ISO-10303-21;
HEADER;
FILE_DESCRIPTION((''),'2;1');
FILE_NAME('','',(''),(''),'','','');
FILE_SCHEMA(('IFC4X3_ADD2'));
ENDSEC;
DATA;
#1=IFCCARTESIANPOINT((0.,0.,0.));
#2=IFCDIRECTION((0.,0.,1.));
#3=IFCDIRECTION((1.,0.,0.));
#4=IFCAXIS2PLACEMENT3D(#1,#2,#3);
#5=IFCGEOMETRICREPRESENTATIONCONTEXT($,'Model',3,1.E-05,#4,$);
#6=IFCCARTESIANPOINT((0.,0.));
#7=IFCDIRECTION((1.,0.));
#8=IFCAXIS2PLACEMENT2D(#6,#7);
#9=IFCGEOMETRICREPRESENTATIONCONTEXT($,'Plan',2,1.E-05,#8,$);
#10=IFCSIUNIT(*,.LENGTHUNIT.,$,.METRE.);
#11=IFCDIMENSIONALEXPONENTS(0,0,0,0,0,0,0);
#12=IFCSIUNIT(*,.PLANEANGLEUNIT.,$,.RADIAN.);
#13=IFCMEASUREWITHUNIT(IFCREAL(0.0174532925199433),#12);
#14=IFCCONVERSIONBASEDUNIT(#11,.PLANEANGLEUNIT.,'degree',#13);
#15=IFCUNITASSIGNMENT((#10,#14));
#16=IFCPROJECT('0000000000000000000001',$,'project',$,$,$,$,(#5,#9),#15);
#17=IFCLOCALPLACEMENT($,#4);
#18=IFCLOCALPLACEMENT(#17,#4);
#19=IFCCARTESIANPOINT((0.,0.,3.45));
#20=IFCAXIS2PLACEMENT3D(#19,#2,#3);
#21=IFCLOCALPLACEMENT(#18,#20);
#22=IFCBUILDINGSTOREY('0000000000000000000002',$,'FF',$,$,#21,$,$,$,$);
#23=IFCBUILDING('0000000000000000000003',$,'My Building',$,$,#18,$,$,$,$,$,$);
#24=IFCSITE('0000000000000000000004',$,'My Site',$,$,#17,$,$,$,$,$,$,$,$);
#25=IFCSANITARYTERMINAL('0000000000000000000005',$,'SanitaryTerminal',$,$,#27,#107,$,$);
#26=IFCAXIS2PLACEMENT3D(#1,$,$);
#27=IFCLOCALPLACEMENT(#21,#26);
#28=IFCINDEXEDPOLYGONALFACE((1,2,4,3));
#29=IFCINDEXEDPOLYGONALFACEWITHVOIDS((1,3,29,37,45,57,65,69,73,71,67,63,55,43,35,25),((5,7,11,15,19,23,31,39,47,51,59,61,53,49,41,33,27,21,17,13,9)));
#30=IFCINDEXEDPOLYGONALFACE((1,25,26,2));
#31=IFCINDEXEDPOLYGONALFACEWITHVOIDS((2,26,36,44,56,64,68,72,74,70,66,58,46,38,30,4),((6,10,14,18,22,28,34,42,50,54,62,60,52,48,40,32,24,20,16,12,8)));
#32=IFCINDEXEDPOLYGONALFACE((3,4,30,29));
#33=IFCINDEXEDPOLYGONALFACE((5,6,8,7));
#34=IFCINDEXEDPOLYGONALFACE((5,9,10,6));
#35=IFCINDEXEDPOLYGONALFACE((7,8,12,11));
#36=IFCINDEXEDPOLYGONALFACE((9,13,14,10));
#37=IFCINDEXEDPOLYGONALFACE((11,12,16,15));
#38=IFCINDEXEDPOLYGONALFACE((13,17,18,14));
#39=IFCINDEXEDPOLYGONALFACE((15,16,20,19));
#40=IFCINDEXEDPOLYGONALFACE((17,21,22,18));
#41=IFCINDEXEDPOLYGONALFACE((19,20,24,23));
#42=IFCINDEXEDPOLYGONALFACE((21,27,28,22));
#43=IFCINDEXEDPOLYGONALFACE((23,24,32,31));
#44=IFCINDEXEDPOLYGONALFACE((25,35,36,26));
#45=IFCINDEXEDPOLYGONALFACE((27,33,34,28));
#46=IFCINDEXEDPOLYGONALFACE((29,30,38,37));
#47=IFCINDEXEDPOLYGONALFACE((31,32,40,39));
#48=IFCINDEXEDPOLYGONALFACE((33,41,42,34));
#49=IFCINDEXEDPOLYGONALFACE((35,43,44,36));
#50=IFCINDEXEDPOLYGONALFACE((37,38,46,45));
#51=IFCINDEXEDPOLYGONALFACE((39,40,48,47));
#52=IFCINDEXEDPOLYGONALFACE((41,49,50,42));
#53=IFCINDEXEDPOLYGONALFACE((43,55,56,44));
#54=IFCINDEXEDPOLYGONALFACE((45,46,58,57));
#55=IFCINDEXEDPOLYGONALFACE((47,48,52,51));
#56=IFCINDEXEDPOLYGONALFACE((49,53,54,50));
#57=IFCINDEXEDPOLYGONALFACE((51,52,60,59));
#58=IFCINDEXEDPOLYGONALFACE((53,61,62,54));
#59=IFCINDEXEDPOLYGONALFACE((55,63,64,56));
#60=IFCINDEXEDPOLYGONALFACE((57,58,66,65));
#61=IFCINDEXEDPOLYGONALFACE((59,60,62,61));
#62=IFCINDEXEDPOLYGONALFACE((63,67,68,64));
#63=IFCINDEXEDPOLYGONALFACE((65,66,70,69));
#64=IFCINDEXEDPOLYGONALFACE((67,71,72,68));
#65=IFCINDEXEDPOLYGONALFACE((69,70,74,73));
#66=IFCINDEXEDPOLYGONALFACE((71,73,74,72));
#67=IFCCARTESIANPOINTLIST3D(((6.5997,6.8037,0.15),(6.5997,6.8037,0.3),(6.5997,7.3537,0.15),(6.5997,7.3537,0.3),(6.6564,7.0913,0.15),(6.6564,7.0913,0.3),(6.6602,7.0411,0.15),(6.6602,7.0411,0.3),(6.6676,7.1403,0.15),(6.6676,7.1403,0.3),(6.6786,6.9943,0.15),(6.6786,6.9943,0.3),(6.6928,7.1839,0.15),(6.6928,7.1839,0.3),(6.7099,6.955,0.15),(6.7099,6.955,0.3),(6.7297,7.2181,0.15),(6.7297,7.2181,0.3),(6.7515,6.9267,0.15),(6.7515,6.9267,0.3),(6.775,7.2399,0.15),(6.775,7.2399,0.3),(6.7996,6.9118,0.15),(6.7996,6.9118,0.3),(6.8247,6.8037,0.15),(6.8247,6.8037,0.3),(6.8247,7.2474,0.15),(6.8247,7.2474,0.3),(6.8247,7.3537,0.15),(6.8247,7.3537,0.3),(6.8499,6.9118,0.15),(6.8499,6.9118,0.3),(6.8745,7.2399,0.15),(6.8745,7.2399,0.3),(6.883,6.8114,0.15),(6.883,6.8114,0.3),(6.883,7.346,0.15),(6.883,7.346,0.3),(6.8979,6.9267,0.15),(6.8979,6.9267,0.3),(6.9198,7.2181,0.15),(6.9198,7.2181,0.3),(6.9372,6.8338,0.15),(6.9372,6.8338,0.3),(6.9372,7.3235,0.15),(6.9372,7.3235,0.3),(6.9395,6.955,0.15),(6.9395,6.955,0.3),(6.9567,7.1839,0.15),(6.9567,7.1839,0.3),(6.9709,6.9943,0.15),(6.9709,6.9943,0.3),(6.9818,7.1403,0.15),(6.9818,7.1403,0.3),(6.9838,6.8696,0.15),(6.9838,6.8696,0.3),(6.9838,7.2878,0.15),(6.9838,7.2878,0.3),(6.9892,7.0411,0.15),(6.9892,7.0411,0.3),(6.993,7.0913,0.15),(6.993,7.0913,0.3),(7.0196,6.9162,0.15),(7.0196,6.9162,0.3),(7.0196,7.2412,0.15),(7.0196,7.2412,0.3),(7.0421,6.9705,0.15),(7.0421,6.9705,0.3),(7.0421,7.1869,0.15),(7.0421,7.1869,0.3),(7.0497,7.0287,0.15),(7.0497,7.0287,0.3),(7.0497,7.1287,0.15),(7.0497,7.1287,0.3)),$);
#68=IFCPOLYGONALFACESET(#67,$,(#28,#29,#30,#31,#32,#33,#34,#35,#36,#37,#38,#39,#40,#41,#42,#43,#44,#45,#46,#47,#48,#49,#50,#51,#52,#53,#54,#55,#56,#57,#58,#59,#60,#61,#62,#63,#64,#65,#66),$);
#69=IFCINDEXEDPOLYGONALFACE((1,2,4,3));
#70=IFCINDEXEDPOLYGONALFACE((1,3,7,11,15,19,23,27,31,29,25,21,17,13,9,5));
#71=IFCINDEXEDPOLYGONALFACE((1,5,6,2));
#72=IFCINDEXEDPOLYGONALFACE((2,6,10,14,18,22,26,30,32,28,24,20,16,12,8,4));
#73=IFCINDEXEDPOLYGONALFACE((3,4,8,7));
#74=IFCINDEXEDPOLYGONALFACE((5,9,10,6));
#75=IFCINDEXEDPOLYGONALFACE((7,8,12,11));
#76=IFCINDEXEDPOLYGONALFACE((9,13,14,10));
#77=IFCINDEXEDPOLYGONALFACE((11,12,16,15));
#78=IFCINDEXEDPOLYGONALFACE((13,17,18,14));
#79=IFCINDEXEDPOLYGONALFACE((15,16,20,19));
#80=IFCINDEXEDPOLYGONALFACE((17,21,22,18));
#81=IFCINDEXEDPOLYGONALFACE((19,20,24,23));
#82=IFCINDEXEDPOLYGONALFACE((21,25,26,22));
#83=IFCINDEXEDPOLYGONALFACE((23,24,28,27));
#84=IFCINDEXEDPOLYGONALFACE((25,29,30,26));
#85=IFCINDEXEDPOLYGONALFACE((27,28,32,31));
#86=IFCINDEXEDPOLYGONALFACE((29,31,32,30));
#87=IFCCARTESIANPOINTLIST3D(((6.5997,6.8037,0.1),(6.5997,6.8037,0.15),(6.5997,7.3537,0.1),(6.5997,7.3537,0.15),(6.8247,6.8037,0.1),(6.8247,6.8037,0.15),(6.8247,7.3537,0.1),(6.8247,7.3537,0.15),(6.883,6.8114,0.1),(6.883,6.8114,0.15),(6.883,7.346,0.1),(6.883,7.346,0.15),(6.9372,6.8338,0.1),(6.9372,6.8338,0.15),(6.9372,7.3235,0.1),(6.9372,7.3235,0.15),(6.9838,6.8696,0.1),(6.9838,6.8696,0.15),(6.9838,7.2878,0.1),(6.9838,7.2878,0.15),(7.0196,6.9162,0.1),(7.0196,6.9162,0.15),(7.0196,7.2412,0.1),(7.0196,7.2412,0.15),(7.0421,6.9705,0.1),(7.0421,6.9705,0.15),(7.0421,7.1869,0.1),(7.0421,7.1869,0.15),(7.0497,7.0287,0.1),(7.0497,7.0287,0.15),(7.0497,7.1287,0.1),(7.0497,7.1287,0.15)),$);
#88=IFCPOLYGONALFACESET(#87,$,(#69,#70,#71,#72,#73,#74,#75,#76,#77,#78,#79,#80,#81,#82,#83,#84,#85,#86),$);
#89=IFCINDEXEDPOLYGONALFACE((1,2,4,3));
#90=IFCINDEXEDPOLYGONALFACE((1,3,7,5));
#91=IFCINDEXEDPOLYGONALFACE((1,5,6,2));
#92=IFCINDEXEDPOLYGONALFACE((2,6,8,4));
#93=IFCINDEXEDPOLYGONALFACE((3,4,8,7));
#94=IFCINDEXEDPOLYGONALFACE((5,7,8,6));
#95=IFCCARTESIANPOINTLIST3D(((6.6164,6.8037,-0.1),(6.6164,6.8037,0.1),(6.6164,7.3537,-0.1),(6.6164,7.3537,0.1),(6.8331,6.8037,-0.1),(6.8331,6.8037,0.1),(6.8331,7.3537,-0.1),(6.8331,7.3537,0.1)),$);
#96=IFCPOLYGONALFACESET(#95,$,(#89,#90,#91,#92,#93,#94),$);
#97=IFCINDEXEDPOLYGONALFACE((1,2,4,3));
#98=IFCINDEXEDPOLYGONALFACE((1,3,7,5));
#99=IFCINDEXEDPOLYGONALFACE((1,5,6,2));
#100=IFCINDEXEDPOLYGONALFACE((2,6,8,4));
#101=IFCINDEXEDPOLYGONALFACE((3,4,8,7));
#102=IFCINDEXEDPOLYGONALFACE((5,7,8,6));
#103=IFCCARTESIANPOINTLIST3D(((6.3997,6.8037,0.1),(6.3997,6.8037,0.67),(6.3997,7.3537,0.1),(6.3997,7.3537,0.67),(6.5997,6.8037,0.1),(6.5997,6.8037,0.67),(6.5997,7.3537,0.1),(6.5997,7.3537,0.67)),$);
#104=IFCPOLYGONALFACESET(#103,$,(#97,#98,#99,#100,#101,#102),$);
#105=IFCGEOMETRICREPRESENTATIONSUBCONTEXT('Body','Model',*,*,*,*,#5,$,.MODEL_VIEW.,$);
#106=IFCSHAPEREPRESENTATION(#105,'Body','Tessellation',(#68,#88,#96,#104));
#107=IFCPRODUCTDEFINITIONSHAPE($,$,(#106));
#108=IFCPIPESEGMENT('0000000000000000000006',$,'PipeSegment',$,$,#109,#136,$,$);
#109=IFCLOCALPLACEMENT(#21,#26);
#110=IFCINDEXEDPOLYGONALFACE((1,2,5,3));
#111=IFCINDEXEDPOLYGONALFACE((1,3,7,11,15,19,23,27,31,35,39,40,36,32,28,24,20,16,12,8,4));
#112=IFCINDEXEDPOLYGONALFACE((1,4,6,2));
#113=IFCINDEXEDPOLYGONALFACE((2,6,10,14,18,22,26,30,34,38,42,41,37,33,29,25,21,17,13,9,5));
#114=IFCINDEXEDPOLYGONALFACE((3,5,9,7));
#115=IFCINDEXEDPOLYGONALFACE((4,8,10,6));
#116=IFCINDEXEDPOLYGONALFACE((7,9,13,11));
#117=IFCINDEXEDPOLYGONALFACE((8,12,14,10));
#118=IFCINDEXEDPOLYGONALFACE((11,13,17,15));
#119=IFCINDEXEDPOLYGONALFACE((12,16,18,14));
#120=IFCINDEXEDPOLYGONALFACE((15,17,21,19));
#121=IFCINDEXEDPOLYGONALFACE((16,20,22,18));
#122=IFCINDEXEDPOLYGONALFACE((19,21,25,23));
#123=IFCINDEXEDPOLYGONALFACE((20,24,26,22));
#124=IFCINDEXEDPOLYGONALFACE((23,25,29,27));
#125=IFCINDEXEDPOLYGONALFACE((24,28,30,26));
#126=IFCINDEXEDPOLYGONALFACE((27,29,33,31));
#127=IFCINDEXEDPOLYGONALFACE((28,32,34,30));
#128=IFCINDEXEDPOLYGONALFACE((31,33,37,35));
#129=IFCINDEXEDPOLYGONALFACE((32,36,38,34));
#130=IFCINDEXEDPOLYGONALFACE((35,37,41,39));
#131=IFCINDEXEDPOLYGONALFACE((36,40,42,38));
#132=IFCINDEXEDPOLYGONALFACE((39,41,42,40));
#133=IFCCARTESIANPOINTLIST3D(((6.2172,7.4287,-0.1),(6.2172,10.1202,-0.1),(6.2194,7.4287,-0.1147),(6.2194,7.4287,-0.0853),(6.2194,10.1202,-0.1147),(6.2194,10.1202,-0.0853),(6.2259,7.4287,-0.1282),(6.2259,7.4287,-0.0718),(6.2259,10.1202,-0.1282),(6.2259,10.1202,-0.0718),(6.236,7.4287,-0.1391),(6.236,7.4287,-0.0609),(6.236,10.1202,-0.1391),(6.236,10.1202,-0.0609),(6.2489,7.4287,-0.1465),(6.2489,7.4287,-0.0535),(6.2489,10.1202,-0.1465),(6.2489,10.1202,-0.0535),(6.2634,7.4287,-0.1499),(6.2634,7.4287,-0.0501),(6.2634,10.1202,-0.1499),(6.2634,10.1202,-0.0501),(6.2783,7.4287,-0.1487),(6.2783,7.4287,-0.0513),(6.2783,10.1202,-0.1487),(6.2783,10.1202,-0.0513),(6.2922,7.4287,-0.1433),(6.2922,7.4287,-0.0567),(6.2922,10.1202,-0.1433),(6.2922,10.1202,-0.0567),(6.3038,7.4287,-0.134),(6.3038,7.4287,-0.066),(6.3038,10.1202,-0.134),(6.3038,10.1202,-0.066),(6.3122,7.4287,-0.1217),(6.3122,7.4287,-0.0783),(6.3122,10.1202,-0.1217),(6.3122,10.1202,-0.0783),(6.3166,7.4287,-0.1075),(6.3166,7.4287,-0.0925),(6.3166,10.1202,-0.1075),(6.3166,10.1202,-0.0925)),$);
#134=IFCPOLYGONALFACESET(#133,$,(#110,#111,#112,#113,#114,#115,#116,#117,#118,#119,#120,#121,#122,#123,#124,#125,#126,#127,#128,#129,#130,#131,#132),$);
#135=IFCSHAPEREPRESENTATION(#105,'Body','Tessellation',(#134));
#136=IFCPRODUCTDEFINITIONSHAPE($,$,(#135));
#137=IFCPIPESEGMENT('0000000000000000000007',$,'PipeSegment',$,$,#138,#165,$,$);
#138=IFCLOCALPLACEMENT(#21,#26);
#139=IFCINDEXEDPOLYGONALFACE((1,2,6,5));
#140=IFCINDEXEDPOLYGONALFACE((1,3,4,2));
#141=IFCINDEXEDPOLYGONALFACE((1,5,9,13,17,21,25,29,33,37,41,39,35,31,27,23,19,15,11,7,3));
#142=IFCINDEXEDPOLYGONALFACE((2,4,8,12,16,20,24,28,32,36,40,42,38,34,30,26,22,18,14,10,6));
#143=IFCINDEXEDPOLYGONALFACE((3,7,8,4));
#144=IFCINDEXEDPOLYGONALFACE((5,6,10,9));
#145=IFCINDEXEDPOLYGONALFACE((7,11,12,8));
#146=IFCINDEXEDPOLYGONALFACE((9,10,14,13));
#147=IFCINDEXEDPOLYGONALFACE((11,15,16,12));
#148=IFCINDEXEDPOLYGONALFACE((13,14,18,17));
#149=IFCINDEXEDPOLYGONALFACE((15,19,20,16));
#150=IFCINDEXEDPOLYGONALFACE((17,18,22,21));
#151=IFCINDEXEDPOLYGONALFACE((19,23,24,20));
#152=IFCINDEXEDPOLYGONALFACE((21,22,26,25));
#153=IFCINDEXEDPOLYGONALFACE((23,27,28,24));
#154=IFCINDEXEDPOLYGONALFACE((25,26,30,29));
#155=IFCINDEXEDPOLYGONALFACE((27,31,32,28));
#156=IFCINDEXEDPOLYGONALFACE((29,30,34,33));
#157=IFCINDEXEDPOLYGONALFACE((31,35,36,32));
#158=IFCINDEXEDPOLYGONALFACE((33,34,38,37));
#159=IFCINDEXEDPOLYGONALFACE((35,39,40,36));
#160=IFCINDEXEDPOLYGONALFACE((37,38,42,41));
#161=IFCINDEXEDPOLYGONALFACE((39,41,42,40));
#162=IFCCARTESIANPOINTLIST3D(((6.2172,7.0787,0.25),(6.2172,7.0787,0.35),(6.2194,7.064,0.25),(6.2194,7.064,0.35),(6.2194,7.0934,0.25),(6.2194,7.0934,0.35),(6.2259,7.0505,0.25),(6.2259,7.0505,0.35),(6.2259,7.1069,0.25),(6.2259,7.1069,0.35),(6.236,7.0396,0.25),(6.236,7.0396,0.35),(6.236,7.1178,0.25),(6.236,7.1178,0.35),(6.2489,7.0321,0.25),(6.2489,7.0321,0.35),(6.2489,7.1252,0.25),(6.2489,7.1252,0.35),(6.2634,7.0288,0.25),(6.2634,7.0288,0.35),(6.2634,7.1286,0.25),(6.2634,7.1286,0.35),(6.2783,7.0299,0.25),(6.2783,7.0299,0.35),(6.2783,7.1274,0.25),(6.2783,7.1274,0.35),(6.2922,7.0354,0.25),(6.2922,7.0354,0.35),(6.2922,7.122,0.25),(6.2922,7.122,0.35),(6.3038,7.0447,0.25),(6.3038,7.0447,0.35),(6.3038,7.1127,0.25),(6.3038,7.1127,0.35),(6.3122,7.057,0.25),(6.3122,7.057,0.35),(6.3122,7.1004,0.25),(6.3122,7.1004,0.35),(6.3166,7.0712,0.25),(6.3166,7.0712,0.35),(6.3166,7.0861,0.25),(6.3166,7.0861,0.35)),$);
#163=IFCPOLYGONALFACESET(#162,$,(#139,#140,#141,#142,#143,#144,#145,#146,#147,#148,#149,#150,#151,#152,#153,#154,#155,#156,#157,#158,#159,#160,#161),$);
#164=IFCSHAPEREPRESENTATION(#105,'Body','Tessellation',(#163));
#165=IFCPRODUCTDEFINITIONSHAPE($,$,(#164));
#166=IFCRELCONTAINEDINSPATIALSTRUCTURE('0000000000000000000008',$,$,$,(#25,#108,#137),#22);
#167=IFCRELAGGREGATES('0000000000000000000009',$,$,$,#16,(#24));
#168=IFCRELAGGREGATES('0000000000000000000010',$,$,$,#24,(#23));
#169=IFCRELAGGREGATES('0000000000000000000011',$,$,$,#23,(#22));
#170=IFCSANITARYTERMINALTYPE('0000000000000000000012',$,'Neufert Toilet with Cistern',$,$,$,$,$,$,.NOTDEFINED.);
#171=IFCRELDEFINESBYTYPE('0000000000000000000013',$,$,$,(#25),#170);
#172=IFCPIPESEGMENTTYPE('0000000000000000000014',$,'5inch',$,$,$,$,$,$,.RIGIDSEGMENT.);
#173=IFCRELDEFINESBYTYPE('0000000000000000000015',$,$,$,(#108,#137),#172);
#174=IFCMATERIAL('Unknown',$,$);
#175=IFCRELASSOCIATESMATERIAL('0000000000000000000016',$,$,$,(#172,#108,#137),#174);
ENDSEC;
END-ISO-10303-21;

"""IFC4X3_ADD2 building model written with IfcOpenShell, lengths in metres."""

from ifc_helpers import new_model, entity, si_unit, converted_unit, frame, frame_2d, origin_with_axes, origin_2d_with_axis, place, context, subcontext, project, spatial, line, arc, indexed_curve, circle_curve, circle, outline, extrude, shape, source, transform, mapped, material, material_profile, profile_set, profile_usage, type_object, type_shapes, element, save


model = new_model("IFC4X3_ADD2")

# Units and contexts
model_context = context("Model", 3, precision=1e-05, world=origin_with_axes())
plan_context = context("Plan", 2, precision=1e-05, world=origin_2d_with_axis())
body_context_1 = subcontext(model_context, "Body", "Model", "MODEL_VIEW")
body_context_2 = subcontext(plan_context, "Body", "Plan", "PLAN_VIEW")
ifc_project = project(units=[si_unit("LENGTHUNIT", "METRE"), converted_unit("PLANEANGLEUNIT", "degree", entity("IfcReal", 0.0174532925199433), si_unit("PLANEANGLEUNIT", "RADIAN"), dimensions=[0, 0, 0, 0, 0, 0, 0])], contexts=[model_context, plan_context])

# Site, building, storey
site_placement = place(None, origin_with_axes())
site = spatial("IfcSite", under=ifc_project, at=site_placement, Name="My Site")
building_placement = place(site_placement, origin_with_axes())
building = spatial("IfcBuilding", under=site, at=building_placement, Name="My Building")
storey_placement = place(building_placement, frame((0.0, 0.0, 3.45), z_axis=(0.0, 0.0, 1.0), x_axis=(1.0, 0.0, 0.0)))
storey = spatial("IfcBuildingStorey", under=building, at=storey_placement, Name="FF")

# Shared definitions
ifc_material = material(Name="Unknown")

# Sanitary terminal
sanitary_terminal_type = type_object("IfcSanitaryTerminalType", Name="Neufert Toilet with Cistern", PredefinedType="NOTDEFINED")
shared_shape_1 = source(origin_with_axes(), body_context_1, "Body", "SweptSolid", [
    extrude(outline(indexed_curve([(-0.275, -0.2), (0.275, -0.2), (0.275, -0.425), (0.2091, -0.5841), (0.05, -0.65), (-0.05, -0.65), (-0.2091, -0.5841), (-0.275, -0.425), (0.0, -0.5938), (0.0, -0.2563)], segments=[arc(8, 7, 6), line(6, 5), arc(5, 4, 3), line(3, 2), line(2, 1), line(1, 8)], self_intersect=False), holes=[circle_curve(frame_2d((0.0, -0.425)), 0.1687)]), frame((0.0, 0.0, 0.25), z_axis=(0.0, 0.0, 1.0), x_axis=(1.0, 0.0, 0.0)), (0.0, 0.0, 1.0), 0.15),
    extrude(outline(indexed_curve([(-0.275, -0.2), (0.275, -0.2), (0.275, -0.425), (0.2091, -0.5841), (0.05, -0.65), (-0.05, -0.65), (-0.2091, -0.5841), (-0.275, -0.425)], segments=[line(1, 2), line(2, 3), arc(3, 4, 5), line(5, 6), arc(6, 7, 8), line(8, 1)])), frame((0.0, 0.0, 0.2), z_axis=(0.0, 0.0, 1.0), x_axis=(1.0, 0.0, 0.0)), (0.0, 0.0, 1.0), 0.05),
    extrude(outline(indexed_curve([(-0.275, -0.2167), (0.275, -0.2167), (0.275, -0.4333), (-0.275, -0.4333)], segments=[line(1, 2, 3, 4, 1)])), origin_with_axes(), (0.0, 0.0, 1.0), 0.2),
    extrude(outline(indexed_curve([(-0.275, 0.0), (0.275, 0.0), (0.275, -0.2), (-0.275, -0.2)], segments=[line(1, 2, 3, 4, 1)])), frame((0.0, 0.0, 0.2), z_axis=(0.0, 0.0, 1.0), x_axis=(1.0, 0.0, 0.0)), (0.0, 0.0, 1.0), 0.57),
])
shared_shape_2 = source(origin_with_axes(), body_context_2, "Body", "Curve2D", [
    entity("IfcIndexedPolyCurve", entity("IfcCartesianPointList2D", [[-0.275, 0.0], [0.275, 0.0], [0.275, -0.2], [-0.275, -0.2]]), [entity("IfcLineIndex", [1, 2, 3, 4, 1])]),
    entity("IfcIndexedPolyCurve", entity("IfcCartesianPointList2D", [[0.165, -0.2], [0.1925, -0.335]])),
    entity("IfcTrimmedCurve", entity("IfcEllipse", entity("IfcAxis2Placement2D", entity("IfcCartesianPoint", [0.0, -0.335]), entity("IfcDirection", [1.0, 0.0])), 0.1925, 0.315), [entity("IfcCartesianPoint", [-0.1925, -0.335])], [entity("IfcCartesianPoint", [0.1925, -0.335])], True, "CARTESIAN"),
    entity("IfcIndexedPolyCurve", entity("IfcCartesianPointList2D", [[-0.165, -0.2], [-0.1925, -0.335]])),
    entity("IfcEllipse", entity("IfcAxis2Placement2D", entity("IfcCartesianPoint", [0.0, -0.452]), entity("IfcDirection", [1.0, 0.0])), 0.1313, 0.1575),
    entity("IfcIndexedPolyCurve", entity("IfcCartesianPointList2D", [[-0.0344, -0.452], [-0.0344, -0.4295], [0.0344, -0.4295], [0.0344, -0.452]])),
    entity("IfcTrimmedCurve", entity("IfcEllipse", entity("IfcAxis2Placement2D", entity("IfcCartesianPoint", [0.0, -0.452]), entity("IfcDirection", [1.0, 0.0])), 0.0344, 0.0225), [entity("IfcCartesianPoint", [-0.0344, -0.452])], [entity("IfcCartesianPoint", [0.0344, -0.452])], True, "CARTESIAN"),
])
type_shapes(sanitary_terminal_type, [shared_shape_1, shared_shape_2])
sanitary_terminal_placement = place(storey_placement, frame((6.3997, 7.0787, -0.1), z_axis=(0.0, 0.0, 1.0), x_axis=(0.0, 1.0, 0.0)))
element("IfcSanitaryTerminal", 1, at=sanitary_terminal_placement, inside=storey, type_object=sanitary_terminal_type, Name="SanitaryTerminal", shapes=[
    shape(body_context_1, "Body", "MappedRepresentation", [mapped(shared_shape_1, transform((0.0, 0.0, 0.0), x_axis=(1.0, 0.0, 0.0), y_axis=(0.0, 1.0, 0.0), z_axis=(0.0, 0.0, 1.0), scale=1.0))]),
    shape(body_context_2, "Body", "MappedRepresentation", [mapped(shared_shape_2, transform((0.0, 0.0, 0.0), x_axis=(1.0, 0.0, 0.0), y_axis=(0.0, 1.0, 0.0), z_axis=(0.0, 0.0, 1.0), scale=1.0))]),
])

# Pipe segments
ifc_material_profile_1 = material_profile(ifc_material, circle(Radius=0.05))
ifc_profile_set_1 = profile_set([ifc_material_profile_1])
ifc_profile_usage_1 = profile_usage(ifc_profile_set_1, cardinal=5)
pipe_segment_type_1 = type_object("IfcPipeSegmentType", Name="5inch", PredefinedType="RIGIDSEGMENT", material=ifc_profile_set_1)
pipe_segment_1_placement = place(storey_placement, frame((6.2672, 7.4287, -0.1), z_axis=(0.0, 1.0, 0.0), x_axis=(-1.0, 0.0, 0.0)))
element("IfcPipeSegment", 2, at=pipe_segment_1_placement, inside=storey, type_object=pipe_segment_type_1, material=ifc_profile_usage_1, Name="PipeSegment", context=body_context_1, shape_type="SweptSolid", body=[
    extrude(circle(Radius=0.05), origin_with_axes(), (0.0, 0.0, 1.0), 2.6915),
])
ifc_profile_usage_2 = profile_usage(ifc_profile_set_1, cardinal=5)
pipe_segment_2_placement = place(storey_placement, frame((6.2672, 7.0787, 0.25), z_axis=(0.0, 0.0, 1.0), x_axis=(-1.0, 0.0, 0.0)))
element("IfcPipeSegment", 3, at=pipe_segment_2_placement, inside=storey, type_object=pipe_segment_type_1, material=ifc_profile_usage_2, Name="PipeSegment", context=body_context_1, shape_type="SweptSolid", body=[
    extrude(circle(Radius=0.05), origin_with_axes(), (0.0, 0.0, 1.0), 0.1),
])

save(model, "model.ifc")
